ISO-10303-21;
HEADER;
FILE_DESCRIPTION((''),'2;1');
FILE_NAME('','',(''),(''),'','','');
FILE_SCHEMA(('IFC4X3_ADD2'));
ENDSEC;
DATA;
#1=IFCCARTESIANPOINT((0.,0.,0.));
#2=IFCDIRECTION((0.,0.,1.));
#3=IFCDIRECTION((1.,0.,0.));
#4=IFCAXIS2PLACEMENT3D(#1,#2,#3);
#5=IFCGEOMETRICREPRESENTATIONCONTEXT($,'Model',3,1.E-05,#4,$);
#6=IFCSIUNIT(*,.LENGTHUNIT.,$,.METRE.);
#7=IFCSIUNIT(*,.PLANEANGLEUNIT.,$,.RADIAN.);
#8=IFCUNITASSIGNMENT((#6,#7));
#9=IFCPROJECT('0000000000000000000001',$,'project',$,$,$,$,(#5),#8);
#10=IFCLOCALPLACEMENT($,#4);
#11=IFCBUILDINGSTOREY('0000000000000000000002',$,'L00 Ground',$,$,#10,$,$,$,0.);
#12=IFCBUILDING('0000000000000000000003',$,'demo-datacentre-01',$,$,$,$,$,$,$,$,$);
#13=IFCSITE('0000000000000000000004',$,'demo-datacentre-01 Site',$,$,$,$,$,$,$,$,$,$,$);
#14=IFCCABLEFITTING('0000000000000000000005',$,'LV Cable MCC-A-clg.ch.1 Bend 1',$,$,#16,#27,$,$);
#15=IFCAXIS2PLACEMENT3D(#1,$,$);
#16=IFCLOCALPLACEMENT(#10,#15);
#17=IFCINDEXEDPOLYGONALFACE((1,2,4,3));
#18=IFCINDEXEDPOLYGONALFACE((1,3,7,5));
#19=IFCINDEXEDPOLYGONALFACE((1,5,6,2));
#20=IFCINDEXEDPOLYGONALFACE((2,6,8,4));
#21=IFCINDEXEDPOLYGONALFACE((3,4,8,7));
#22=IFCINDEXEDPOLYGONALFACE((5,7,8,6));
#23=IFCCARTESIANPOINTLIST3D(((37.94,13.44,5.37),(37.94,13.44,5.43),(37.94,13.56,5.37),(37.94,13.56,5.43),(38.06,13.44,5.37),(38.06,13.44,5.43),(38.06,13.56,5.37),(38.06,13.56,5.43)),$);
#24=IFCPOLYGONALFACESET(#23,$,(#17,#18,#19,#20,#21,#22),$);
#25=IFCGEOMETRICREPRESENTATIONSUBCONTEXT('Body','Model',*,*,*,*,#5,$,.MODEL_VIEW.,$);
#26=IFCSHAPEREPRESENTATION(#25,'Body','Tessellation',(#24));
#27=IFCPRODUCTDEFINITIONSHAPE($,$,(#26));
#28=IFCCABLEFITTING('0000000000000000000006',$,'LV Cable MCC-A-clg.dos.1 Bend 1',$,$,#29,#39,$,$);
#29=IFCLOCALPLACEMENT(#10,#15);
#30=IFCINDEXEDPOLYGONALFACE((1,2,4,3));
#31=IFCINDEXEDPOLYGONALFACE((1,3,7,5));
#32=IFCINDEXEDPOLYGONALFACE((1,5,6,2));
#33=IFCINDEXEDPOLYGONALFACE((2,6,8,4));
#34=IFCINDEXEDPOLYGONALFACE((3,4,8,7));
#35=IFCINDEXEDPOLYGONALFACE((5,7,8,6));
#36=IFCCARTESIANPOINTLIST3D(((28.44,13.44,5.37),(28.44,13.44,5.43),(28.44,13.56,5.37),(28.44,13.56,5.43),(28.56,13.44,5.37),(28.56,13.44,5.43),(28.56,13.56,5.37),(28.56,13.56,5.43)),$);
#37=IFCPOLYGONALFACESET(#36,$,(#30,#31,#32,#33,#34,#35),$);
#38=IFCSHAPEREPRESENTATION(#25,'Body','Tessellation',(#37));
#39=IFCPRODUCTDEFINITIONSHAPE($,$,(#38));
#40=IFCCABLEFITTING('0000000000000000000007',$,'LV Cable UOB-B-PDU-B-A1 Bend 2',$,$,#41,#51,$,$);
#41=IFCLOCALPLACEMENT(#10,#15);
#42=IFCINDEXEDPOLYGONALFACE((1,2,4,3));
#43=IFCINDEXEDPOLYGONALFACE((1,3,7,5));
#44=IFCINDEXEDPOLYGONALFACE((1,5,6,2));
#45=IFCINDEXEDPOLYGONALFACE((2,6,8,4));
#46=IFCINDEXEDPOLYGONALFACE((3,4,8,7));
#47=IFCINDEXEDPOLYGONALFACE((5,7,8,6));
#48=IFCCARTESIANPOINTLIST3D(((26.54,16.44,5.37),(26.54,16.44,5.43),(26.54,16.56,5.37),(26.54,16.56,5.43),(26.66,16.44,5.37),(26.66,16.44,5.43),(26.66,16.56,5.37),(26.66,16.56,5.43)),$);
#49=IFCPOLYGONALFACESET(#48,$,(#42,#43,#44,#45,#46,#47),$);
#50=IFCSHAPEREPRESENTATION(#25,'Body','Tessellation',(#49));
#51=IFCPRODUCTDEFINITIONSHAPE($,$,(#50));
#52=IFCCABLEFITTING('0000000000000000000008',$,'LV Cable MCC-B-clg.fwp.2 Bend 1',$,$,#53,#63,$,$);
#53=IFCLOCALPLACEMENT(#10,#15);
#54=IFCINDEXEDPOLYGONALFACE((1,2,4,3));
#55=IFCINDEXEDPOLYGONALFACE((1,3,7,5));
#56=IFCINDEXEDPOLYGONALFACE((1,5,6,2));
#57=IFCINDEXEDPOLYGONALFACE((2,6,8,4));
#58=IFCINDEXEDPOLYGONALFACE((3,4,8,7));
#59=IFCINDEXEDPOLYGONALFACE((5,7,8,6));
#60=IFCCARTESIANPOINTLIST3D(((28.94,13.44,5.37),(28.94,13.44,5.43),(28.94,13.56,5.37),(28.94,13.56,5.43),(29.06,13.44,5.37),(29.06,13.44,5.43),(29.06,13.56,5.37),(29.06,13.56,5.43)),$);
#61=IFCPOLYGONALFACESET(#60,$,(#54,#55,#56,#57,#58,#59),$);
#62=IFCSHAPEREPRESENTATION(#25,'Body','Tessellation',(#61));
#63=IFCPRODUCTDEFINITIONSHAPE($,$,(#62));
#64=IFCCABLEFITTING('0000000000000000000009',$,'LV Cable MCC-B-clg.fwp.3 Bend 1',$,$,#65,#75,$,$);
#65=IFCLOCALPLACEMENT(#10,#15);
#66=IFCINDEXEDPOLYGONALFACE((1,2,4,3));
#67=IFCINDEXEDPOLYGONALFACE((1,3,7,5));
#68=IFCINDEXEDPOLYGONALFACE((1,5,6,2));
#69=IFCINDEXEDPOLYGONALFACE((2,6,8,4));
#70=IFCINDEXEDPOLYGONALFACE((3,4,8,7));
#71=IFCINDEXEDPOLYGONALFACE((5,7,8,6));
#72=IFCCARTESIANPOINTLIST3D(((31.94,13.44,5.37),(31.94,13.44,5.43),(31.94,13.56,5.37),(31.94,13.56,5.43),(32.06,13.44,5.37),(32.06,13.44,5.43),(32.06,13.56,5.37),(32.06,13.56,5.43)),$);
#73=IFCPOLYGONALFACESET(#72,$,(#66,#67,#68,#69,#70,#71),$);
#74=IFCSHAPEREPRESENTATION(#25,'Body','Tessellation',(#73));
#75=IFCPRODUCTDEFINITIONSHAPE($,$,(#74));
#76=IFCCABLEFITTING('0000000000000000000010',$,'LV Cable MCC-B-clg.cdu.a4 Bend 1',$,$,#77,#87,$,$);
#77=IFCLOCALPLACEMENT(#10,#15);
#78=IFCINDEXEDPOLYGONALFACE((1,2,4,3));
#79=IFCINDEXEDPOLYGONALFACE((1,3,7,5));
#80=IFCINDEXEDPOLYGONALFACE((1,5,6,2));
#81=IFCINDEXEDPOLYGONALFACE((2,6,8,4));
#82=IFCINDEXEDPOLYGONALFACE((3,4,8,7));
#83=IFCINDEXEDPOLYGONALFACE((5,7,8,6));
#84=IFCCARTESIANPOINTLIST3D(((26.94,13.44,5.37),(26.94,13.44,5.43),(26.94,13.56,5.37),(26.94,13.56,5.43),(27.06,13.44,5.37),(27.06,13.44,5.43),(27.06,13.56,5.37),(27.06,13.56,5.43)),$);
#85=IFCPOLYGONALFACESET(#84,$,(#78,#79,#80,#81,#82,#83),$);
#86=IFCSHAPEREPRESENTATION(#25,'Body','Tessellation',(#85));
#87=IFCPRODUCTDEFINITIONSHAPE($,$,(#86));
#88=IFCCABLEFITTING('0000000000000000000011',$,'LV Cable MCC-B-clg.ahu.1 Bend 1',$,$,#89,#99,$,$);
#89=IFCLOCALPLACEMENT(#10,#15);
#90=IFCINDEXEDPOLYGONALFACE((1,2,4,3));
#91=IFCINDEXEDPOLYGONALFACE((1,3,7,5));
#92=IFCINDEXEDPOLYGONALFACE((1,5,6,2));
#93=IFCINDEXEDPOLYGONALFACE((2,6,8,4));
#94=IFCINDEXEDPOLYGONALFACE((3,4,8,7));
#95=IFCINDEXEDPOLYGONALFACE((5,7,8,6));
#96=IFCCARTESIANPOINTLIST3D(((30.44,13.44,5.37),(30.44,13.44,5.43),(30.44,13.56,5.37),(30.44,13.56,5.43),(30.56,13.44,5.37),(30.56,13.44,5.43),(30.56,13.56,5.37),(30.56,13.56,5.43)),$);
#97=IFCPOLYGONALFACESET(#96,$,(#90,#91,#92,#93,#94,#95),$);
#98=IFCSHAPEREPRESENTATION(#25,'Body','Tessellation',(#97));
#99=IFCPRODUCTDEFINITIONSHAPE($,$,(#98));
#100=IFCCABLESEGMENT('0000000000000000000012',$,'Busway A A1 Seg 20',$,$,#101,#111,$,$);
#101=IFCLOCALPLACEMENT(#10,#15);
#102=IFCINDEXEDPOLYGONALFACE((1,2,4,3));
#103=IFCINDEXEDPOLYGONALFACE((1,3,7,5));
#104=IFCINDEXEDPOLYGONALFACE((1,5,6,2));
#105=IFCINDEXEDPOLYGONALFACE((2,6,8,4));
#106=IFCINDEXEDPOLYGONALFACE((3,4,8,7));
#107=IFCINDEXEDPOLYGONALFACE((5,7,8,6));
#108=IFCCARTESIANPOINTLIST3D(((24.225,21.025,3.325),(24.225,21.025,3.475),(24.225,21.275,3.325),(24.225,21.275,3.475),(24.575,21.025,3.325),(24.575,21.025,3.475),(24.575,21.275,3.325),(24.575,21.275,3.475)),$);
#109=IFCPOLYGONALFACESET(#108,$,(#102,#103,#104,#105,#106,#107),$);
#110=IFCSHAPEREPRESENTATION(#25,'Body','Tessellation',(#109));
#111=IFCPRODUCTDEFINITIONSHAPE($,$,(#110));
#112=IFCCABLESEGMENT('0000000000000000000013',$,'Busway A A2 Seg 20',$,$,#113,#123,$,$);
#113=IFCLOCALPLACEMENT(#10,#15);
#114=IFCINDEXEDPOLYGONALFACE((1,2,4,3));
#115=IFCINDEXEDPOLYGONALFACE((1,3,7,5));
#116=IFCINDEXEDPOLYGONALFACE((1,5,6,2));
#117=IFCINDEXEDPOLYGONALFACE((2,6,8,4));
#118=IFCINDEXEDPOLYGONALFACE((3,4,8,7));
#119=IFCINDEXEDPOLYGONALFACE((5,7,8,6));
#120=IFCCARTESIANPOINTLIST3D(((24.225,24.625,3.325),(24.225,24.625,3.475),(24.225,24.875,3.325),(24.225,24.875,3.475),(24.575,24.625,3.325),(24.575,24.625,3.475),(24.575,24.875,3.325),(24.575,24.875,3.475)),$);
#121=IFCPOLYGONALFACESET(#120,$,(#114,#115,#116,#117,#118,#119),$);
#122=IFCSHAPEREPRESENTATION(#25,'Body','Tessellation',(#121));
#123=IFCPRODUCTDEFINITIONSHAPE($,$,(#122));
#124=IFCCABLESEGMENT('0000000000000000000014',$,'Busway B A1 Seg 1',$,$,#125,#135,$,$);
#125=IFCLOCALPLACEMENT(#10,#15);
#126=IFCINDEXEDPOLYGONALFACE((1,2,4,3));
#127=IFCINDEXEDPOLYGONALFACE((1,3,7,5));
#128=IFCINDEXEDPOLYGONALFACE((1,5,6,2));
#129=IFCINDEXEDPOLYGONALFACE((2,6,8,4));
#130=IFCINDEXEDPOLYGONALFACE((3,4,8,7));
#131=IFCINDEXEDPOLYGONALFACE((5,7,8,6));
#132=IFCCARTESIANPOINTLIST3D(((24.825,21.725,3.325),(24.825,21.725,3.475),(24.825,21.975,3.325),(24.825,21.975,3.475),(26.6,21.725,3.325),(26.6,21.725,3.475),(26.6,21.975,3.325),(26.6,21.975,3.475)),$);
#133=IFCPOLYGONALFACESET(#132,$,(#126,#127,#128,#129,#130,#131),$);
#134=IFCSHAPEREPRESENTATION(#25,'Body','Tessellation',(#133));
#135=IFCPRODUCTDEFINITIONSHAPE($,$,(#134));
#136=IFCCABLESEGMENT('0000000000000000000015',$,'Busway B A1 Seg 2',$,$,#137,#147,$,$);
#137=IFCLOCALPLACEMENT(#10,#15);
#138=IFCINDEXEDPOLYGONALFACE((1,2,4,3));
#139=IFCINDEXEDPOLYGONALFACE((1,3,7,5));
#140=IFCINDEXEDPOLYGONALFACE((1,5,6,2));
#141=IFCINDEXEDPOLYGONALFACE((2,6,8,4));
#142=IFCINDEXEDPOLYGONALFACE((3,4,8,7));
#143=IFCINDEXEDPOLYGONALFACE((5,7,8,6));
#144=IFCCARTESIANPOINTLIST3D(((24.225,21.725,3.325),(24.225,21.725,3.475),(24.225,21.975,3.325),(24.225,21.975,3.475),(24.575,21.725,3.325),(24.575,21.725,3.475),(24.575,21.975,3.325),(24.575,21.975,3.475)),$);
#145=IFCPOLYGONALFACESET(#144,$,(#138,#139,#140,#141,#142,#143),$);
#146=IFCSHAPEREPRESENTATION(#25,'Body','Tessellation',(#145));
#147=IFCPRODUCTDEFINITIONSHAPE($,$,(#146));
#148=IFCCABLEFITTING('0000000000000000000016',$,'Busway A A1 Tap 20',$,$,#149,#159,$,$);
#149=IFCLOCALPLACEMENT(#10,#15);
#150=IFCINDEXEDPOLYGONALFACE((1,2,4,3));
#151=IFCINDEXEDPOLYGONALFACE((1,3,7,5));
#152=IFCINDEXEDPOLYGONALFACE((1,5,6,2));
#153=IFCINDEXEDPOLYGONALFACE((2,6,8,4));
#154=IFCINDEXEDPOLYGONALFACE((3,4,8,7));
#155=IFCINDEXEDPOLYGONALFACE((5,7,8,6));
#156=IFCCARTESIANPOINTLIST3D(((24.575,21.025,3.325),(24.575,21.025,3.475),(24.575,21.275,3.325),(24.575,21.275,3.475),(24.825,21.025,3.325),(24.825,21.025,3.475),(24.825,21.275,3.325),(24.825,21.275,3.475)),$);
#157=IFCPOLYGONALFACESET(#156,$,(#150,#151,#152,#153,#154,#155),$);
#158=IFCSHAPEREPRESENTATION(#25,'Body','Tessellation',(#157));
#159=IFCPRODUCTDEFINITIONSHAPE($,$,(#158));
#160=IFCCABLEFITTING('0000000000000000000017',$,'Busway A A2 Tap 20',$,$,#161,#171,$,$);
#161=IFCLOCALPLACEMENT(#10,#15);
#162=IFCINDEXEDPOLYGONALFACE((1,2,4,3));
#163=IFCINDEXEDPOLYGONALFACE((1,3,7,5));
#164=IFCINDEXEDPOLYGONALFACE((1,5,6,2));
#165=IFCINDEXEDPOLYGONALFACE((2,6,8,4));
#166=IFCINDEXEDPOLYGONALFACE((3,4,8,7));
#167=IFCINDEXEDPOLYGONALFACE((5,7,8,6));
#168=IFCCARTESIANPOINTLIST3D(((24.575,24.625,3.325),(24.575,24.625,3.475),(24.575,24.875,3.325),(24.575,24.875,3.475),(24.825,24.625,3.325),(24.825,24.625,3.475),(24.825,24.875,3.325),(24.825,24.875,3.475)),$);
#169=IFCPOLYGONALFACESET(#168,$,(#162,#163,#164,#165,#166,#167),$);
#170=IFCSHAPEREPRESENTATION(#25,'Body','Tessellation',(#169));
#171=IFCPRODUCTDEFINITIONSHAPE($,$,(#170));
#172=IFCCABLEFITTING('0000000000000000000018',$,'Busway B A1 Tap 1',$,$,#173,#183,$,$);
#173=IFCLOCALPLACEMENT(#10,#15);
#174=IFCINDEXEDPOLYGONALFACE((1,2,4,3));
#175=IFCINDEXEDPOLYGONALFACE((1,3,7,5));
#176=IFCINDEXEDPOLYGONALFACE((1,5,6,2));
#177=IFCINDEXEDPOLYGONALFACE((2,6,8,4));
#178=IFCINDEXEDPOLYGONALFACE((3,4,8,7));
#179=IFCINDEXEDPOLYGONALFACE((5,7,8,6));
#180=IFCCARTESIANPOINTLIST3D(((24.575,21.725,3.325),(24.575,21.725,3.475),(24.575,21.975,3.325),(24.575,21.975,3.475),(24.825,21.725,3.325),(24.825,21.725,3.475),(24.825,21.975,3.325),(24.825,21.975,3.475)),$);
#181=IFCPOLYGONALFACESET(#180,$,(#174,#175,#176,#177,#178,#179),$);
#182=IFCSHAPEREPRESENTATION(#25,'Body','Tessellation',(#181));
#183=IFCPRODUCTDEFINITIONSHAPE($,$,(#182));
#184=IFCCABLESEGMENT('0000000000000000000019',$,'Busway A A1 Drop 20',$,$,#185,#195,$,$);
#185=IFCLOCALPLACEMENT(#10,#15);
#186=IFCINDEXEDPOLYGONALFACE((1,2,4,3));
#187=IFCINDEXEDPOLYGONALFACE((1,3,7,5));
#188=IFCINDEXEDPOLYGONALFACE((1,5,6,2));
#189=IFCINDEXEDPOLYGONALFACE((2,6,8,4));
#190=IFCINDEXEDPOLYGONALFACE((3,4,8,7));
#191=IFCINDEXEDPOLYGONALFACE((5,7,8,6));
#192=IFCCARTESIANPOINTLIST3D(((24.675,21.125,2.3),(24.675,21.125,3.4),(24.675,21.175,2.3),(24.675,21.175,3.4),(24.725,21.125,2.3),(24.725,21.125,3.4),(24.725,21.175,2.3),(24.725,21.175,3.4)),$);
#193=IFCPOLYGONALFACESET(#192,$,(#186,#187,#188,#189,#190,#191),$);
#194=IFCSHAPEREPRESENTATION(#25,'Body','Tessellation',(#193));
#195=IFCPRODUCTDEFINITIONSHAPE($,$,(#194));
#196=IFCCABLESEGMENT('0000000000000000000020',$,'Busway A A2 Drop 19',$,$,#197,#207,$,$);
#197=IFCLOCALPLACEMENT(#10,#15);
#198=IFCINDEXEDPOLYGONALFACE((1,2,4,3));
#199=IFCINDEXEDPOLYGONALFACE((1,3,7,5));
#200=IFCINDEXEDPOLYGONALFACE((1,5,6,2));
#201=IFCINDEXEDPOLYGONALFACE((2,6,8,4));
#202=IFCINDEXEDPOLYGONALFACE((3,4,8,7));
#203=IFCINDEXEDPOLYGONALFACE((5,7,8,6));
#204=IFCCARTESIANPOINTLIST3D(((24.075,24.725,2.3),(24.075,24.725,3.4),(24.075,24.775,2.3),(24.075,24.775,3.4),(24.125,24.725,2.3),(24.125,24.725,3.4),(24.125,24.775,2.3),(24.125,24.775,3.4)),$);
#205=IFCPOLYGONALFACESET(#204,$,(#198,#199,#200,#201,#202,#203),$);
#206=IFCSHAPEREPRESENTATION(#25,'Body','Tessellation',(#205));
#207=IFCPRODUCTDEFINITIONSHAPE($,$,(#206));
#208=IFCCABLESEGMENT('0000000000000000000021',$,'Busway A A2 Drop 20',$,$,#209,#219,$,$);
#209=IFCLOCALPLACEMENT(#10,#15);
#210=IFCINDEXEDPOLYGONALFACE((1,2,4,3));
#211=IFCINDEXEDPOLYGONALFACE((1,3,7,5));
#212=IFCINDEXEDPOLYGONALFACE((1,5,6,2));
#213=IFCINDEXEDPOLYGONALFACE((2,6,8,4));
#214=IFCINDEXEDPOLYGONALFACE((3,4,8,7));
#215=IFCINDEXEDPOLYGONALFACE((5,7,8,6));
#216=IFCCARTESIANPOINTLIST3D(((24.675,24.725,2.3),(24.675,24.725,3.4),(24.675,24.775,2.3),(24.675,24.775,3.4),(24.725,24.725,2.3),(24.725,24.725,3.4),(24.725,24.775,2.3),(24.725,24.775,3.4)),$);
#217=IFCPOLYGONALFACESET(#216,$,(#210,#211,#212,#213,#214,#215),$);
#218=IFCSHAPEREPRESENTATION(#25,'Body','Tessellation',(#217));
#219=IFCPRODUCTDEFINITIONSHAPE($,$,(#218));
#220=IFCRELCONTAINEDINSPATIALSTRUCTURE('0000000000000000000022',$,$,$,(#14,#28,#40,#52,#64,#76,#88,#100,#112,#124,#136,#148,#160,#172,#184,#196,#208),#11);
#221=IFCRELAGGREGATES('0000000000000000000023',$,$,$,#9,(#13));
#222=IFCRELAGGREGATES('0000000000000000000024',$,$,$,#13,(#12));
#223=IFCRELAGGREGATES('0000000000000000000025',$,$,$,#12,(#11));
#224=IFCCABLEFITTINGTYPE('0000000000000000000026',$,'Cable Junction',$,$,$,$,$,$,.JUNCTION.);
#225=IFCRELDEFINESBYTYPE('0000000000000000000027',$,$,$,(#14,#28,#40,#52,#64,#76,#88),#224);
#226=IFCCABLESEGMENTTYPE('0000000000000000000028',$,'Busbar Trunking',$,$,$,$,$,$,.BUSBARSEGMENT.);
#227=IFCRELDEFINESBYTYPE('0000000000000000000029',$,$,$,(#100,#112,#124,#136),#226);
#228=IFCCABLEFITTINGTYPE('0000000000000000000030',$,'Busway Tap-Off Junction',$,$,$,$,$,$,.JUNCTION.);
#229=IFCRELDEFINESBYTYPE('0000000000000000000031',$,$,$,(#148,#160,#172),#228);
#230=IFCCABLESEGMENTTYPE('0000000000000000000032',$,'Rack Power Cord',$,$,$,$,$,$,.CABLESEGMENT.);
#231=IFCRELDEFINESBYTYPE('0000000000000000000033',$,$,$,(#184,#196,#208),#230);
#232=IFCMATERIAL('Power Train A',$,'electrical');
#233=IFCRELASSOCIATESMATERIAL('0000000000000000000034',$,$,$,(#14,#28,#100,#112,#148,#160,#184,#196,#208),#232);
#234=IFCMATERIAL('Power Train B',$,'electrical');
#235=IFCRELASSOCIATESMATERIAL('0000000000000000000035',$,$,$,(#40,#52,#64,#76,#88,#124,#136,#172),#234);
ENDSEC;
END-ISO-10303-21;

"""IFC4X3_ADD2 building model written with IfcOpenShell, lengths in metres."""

from ifc_helpers import new_model, si_unit, frame, origin_with_axes, place, context, subcontext, project, spatial, rectangle, extrude, material, type_object, element, save


model = new_model("IFC4X3_ADD2")

# Units and contexts
model_context = context("Model", 3, precision=1e-05, world=origin_with_axes())
body_context = subcontext(model_context, "Body", "Model", "MODEL_VIEW")
ifc_project = project(units=[si_unit("LENGTHUNIT", "METRE"), si_unit("PLANEANGLEUNIT", "RADIAN")], contexts=[model_context])

# Site, building, storey
site = spatial("IfcSite", under=ifc_project, Name="demo-datacentre-01 Site")
building = spatial("IfcBuilding", under=site, Name="demo-datacentre-01")
storey_placement = place(None, origin_with_axes())
storey = spatial("IfcBuildingStorey", under=building, at=storey_placement, Name="L00 Ground", Elevation=0.0)

# Shared definitions
ifc_material_1 = material(Name="Power Train B", Category="electrical")

# Shared definitions
ifc_material_2 = material(Name="Power Train A", Category="electrical")

# Cable fittings
cable_fitting_type_1 = type_object("IfcCableFittingType", Name="Cable Junction", PredefinedType="JUNCTION")
for number, where, z_axis, x_axis, name in (
    (1, (38.0, 13.5, 5.37), (0.0, 0.0, 1.0), (1.0, 0.0, 0.0), "LV Cable MCC-A-clg.ch.1 Bend 1"),
    (2, (28.5, 13.5, 5.37), (0.0, 0.0, 1.0), (1.0, 0.0, 0.0), "LV Cable MCC-A-clg.dos.1 Bend 1"),
):
    element("IfcCableFitting", number, at=place(storey_placement, frame(where, z_axis=z_axis, x_axis=x_axis)), inside=storey, type_object=cable_fitting_type_1, material=ifc_material_2, Name=name, context=body_context, shape_type="SweptSolid", body=[
        extrude(rectangle(XDim=0.12, YDim=0.12), origin_with_axes(), (0.0, 0.0, 1.0), 0.06),
    ])
for number, where, z_axis, x_axis, name in (
    (3, (26.6, 16.5, 5.37), (0.0, 0.0, 1.0), (1.0, 0.0, 0.0), "LV Cable UOB-B-PDU-B-A1 Bend 2"),
    (4, (29.0, 13.5, 5.37), (0.0, 0.0, 1.0), (1.0, 0.0, 0.0), "LV Cable MCC-B-clg.fwp.2 Bend 1"),
    (5, (32.0, 13.5, 5.37), (0.0, 0.0, 1.0), (1.0, 0.0, 0.0), "LV Cable MCC-B-clg.fwp.3 Bend 1"),
    (6, (27.0, 13.5, 5.37), (0.0, 0.0, 1.0), (1.0, 0.0, 0.0), "LV Cable MCC-B-clg.cdu.a4 Bend 1"),
    (7, (30.5, 13.5, 5.37), (0.0, 0.0, 1.0), (1.0, 0.0, 0.0), "LV Cable MCC-B-clg.ahu.1 Bend 1"),
):
    element("IfcCableFitting", number, at=place(storey_placement, frame(where, z_axis=z_axis, x_axis=x_axis)), inside=storey, type_object=cable_fitting_type_1, material=ifc_material_1, Name=name, context=body_context, shape_type="SweptSolid", body=[
        extrude(rectangle(XDim=0.12, YDim=0.12), origin_with_axes(), (0.0, 0.0, 1.0), 0.06),
    ])

# Cable segments
cable_segment_type_1 = type_object("IfcCableSegmentType", Name="Busbar Trunking", PredefinedType="BUSBARSEGMENT")
for number, where, z_axis, x_axis, name in (
    (8, (24.225, 21.15, 3.4), (1.0, 0.0, 0.0), (0.0, 1.0, 0.0), "Busway A A1 Seg 20"),
    (9, (24.225, 24.75, 3.4), (1.0, 0.0, 0.0), (0.0, 1.0, 0.0), "Busway A A2 Seg 20"),
):
    element("IfcCableSegment", number, at=place(storey_placement, frame(where, z_axis=z_axis, x_axis=x_axis)), inside=storey, type_object=cable_segment_type_1, material=ifc_material_2, Name=name, context=body_context, shape_type="SweptSolid", body=[
        extrude(rectangle(XDim=0.25, YDim=0.15), origin_with_axes(), (0.0, 0.0, 1.0), 0.35),
    ])
cable_segment_1_placement = place(storey_placement, frame((26.6, 21.85, 3.4), z_axis=(-1.0, 0.0, 0.0), x_axis=(0.0, -1.0, 0.0)))
element("IfcCableSegment", 10, at=cable_segment_1_placement, inside=storey, type_object=cable_segment_type_1, material=ifc_material_1, Name="Busway B A1 Seg 1", context=body_context, shape_type="SweptSolid", body=[
    extrude(rectangle(XDim=0.25, YDim=0.15), origin_with_axes(), (0.0, 0.0, 1.0), 1.775),
])
cable_segment_2_placement = place(storey_placement, frame((24.575, 21.85, 3.4), z_axis=(-1.0, 0.0, 0.0), x_axis=(0.0, -1.0, 0.0)))
element("IfcCableSegment", 11, at=cable_segment_2_placement, inside=storey, type_object=cable_segment_type_1, material=ifc_material_1, Name="Busway B A1 Seg 2", context=body_context, shape_type="SweptSolid", body=[
    extrude(rectangle(XDim=0.25, YDim=0.15), origin_with_axes(), (0.0, 0.0, 1.0), 0.35),
])

# Cable fittings
cable_fitting_type_2 = type_object("IfcCableFittingType", Name="Busway Tap-Off Junction", PredefinedType="JUNCTION")
for number, where, z_axis, x_axis, name in (
    (12, (24.7, 21.15, 3.325), (0.0, 0.0, 1.0), (1.0, 0.0, 0.0), "Busway A A1 Tap 20"),
    (13, (24.7, 24.75, 3.325), (0.0, 0.0, 1.0), (1.0, 0.0, 0.0), "Busway A A2 Tap 20"),
):
    element("IfcCableFitting", number, at=place(storey_placement, frame(where, z_axis=z_axis, x_axis=x_axis)), inside=storey, type_object=cable_fitting_type_2, material=ifc_material_2, Name=name, context=body_context, shape_type="SweptSolid", body=[
        extrude(rectangle(XDim=0.25, YDim=0.25), origin_with_axes(), (0.0, 0.0, 1.0), 0.15),
    ])
cable_fitting_placement = place(storey_placement, frame((24.7, 21.85, 3.325), z_axis=(0.0, 0.0, 1.0), x_axis=(1.0, 0.0, 0.0)))
element("IfcCableFitting", 14, at=cable_fitting_placement, inside=storey, type_object=cable_fitting_type_2, material=ifc_material_1, Name="Busway B A1 Tap 1", context=body_context, shape_type="SweptSolid", body=[
    extrude(rectangle(XDim=0.25, YDim=0.25), origin_with_axes(), (0.0, 0.0, 1.0), 0.15),
])

# Cable segments
cable_segment_type_2 = type_object("IfcCableSegmentType", Name="Rack Power Cord", PredefinedType="CABLESEGMENT")
for number, where, z_axis, x_axis, name in (
    (15, (24.7, 21.15, 3.4), (0.0, 0.0, -1.0), (1.0, 0.0, 0.0), "Busway A A1 Drop 20"),
    (16, (24.1, 24.75, 3.4), (0.0, 0.0, -1.0), (1.0, 0.0, 0.0), "Busway A A2 Drop 19"),
    (17, (24.7, 24.75, 3.4), (0.0, 0.0, -1.0), (1.0, 0.0, 0.0), "Busway A A2 Drop 20"),
):
    element("IfcCableSegment", number, at=place(storey_placement, frame(where, z_axis=z_axis, x_axis=x_axis)), inside=storey, type_object=cable_segment_type_2, material=ifc_material_2, Name=name, context=body_context, shape_type="SweptSolid", body=[
        extrude(rectangle(XDim=0.05, YDim=0.05), origin_with_axes(), (0.0, 0.0, 1.0), 1.1),
    ])

save(model, "model.ifc")
